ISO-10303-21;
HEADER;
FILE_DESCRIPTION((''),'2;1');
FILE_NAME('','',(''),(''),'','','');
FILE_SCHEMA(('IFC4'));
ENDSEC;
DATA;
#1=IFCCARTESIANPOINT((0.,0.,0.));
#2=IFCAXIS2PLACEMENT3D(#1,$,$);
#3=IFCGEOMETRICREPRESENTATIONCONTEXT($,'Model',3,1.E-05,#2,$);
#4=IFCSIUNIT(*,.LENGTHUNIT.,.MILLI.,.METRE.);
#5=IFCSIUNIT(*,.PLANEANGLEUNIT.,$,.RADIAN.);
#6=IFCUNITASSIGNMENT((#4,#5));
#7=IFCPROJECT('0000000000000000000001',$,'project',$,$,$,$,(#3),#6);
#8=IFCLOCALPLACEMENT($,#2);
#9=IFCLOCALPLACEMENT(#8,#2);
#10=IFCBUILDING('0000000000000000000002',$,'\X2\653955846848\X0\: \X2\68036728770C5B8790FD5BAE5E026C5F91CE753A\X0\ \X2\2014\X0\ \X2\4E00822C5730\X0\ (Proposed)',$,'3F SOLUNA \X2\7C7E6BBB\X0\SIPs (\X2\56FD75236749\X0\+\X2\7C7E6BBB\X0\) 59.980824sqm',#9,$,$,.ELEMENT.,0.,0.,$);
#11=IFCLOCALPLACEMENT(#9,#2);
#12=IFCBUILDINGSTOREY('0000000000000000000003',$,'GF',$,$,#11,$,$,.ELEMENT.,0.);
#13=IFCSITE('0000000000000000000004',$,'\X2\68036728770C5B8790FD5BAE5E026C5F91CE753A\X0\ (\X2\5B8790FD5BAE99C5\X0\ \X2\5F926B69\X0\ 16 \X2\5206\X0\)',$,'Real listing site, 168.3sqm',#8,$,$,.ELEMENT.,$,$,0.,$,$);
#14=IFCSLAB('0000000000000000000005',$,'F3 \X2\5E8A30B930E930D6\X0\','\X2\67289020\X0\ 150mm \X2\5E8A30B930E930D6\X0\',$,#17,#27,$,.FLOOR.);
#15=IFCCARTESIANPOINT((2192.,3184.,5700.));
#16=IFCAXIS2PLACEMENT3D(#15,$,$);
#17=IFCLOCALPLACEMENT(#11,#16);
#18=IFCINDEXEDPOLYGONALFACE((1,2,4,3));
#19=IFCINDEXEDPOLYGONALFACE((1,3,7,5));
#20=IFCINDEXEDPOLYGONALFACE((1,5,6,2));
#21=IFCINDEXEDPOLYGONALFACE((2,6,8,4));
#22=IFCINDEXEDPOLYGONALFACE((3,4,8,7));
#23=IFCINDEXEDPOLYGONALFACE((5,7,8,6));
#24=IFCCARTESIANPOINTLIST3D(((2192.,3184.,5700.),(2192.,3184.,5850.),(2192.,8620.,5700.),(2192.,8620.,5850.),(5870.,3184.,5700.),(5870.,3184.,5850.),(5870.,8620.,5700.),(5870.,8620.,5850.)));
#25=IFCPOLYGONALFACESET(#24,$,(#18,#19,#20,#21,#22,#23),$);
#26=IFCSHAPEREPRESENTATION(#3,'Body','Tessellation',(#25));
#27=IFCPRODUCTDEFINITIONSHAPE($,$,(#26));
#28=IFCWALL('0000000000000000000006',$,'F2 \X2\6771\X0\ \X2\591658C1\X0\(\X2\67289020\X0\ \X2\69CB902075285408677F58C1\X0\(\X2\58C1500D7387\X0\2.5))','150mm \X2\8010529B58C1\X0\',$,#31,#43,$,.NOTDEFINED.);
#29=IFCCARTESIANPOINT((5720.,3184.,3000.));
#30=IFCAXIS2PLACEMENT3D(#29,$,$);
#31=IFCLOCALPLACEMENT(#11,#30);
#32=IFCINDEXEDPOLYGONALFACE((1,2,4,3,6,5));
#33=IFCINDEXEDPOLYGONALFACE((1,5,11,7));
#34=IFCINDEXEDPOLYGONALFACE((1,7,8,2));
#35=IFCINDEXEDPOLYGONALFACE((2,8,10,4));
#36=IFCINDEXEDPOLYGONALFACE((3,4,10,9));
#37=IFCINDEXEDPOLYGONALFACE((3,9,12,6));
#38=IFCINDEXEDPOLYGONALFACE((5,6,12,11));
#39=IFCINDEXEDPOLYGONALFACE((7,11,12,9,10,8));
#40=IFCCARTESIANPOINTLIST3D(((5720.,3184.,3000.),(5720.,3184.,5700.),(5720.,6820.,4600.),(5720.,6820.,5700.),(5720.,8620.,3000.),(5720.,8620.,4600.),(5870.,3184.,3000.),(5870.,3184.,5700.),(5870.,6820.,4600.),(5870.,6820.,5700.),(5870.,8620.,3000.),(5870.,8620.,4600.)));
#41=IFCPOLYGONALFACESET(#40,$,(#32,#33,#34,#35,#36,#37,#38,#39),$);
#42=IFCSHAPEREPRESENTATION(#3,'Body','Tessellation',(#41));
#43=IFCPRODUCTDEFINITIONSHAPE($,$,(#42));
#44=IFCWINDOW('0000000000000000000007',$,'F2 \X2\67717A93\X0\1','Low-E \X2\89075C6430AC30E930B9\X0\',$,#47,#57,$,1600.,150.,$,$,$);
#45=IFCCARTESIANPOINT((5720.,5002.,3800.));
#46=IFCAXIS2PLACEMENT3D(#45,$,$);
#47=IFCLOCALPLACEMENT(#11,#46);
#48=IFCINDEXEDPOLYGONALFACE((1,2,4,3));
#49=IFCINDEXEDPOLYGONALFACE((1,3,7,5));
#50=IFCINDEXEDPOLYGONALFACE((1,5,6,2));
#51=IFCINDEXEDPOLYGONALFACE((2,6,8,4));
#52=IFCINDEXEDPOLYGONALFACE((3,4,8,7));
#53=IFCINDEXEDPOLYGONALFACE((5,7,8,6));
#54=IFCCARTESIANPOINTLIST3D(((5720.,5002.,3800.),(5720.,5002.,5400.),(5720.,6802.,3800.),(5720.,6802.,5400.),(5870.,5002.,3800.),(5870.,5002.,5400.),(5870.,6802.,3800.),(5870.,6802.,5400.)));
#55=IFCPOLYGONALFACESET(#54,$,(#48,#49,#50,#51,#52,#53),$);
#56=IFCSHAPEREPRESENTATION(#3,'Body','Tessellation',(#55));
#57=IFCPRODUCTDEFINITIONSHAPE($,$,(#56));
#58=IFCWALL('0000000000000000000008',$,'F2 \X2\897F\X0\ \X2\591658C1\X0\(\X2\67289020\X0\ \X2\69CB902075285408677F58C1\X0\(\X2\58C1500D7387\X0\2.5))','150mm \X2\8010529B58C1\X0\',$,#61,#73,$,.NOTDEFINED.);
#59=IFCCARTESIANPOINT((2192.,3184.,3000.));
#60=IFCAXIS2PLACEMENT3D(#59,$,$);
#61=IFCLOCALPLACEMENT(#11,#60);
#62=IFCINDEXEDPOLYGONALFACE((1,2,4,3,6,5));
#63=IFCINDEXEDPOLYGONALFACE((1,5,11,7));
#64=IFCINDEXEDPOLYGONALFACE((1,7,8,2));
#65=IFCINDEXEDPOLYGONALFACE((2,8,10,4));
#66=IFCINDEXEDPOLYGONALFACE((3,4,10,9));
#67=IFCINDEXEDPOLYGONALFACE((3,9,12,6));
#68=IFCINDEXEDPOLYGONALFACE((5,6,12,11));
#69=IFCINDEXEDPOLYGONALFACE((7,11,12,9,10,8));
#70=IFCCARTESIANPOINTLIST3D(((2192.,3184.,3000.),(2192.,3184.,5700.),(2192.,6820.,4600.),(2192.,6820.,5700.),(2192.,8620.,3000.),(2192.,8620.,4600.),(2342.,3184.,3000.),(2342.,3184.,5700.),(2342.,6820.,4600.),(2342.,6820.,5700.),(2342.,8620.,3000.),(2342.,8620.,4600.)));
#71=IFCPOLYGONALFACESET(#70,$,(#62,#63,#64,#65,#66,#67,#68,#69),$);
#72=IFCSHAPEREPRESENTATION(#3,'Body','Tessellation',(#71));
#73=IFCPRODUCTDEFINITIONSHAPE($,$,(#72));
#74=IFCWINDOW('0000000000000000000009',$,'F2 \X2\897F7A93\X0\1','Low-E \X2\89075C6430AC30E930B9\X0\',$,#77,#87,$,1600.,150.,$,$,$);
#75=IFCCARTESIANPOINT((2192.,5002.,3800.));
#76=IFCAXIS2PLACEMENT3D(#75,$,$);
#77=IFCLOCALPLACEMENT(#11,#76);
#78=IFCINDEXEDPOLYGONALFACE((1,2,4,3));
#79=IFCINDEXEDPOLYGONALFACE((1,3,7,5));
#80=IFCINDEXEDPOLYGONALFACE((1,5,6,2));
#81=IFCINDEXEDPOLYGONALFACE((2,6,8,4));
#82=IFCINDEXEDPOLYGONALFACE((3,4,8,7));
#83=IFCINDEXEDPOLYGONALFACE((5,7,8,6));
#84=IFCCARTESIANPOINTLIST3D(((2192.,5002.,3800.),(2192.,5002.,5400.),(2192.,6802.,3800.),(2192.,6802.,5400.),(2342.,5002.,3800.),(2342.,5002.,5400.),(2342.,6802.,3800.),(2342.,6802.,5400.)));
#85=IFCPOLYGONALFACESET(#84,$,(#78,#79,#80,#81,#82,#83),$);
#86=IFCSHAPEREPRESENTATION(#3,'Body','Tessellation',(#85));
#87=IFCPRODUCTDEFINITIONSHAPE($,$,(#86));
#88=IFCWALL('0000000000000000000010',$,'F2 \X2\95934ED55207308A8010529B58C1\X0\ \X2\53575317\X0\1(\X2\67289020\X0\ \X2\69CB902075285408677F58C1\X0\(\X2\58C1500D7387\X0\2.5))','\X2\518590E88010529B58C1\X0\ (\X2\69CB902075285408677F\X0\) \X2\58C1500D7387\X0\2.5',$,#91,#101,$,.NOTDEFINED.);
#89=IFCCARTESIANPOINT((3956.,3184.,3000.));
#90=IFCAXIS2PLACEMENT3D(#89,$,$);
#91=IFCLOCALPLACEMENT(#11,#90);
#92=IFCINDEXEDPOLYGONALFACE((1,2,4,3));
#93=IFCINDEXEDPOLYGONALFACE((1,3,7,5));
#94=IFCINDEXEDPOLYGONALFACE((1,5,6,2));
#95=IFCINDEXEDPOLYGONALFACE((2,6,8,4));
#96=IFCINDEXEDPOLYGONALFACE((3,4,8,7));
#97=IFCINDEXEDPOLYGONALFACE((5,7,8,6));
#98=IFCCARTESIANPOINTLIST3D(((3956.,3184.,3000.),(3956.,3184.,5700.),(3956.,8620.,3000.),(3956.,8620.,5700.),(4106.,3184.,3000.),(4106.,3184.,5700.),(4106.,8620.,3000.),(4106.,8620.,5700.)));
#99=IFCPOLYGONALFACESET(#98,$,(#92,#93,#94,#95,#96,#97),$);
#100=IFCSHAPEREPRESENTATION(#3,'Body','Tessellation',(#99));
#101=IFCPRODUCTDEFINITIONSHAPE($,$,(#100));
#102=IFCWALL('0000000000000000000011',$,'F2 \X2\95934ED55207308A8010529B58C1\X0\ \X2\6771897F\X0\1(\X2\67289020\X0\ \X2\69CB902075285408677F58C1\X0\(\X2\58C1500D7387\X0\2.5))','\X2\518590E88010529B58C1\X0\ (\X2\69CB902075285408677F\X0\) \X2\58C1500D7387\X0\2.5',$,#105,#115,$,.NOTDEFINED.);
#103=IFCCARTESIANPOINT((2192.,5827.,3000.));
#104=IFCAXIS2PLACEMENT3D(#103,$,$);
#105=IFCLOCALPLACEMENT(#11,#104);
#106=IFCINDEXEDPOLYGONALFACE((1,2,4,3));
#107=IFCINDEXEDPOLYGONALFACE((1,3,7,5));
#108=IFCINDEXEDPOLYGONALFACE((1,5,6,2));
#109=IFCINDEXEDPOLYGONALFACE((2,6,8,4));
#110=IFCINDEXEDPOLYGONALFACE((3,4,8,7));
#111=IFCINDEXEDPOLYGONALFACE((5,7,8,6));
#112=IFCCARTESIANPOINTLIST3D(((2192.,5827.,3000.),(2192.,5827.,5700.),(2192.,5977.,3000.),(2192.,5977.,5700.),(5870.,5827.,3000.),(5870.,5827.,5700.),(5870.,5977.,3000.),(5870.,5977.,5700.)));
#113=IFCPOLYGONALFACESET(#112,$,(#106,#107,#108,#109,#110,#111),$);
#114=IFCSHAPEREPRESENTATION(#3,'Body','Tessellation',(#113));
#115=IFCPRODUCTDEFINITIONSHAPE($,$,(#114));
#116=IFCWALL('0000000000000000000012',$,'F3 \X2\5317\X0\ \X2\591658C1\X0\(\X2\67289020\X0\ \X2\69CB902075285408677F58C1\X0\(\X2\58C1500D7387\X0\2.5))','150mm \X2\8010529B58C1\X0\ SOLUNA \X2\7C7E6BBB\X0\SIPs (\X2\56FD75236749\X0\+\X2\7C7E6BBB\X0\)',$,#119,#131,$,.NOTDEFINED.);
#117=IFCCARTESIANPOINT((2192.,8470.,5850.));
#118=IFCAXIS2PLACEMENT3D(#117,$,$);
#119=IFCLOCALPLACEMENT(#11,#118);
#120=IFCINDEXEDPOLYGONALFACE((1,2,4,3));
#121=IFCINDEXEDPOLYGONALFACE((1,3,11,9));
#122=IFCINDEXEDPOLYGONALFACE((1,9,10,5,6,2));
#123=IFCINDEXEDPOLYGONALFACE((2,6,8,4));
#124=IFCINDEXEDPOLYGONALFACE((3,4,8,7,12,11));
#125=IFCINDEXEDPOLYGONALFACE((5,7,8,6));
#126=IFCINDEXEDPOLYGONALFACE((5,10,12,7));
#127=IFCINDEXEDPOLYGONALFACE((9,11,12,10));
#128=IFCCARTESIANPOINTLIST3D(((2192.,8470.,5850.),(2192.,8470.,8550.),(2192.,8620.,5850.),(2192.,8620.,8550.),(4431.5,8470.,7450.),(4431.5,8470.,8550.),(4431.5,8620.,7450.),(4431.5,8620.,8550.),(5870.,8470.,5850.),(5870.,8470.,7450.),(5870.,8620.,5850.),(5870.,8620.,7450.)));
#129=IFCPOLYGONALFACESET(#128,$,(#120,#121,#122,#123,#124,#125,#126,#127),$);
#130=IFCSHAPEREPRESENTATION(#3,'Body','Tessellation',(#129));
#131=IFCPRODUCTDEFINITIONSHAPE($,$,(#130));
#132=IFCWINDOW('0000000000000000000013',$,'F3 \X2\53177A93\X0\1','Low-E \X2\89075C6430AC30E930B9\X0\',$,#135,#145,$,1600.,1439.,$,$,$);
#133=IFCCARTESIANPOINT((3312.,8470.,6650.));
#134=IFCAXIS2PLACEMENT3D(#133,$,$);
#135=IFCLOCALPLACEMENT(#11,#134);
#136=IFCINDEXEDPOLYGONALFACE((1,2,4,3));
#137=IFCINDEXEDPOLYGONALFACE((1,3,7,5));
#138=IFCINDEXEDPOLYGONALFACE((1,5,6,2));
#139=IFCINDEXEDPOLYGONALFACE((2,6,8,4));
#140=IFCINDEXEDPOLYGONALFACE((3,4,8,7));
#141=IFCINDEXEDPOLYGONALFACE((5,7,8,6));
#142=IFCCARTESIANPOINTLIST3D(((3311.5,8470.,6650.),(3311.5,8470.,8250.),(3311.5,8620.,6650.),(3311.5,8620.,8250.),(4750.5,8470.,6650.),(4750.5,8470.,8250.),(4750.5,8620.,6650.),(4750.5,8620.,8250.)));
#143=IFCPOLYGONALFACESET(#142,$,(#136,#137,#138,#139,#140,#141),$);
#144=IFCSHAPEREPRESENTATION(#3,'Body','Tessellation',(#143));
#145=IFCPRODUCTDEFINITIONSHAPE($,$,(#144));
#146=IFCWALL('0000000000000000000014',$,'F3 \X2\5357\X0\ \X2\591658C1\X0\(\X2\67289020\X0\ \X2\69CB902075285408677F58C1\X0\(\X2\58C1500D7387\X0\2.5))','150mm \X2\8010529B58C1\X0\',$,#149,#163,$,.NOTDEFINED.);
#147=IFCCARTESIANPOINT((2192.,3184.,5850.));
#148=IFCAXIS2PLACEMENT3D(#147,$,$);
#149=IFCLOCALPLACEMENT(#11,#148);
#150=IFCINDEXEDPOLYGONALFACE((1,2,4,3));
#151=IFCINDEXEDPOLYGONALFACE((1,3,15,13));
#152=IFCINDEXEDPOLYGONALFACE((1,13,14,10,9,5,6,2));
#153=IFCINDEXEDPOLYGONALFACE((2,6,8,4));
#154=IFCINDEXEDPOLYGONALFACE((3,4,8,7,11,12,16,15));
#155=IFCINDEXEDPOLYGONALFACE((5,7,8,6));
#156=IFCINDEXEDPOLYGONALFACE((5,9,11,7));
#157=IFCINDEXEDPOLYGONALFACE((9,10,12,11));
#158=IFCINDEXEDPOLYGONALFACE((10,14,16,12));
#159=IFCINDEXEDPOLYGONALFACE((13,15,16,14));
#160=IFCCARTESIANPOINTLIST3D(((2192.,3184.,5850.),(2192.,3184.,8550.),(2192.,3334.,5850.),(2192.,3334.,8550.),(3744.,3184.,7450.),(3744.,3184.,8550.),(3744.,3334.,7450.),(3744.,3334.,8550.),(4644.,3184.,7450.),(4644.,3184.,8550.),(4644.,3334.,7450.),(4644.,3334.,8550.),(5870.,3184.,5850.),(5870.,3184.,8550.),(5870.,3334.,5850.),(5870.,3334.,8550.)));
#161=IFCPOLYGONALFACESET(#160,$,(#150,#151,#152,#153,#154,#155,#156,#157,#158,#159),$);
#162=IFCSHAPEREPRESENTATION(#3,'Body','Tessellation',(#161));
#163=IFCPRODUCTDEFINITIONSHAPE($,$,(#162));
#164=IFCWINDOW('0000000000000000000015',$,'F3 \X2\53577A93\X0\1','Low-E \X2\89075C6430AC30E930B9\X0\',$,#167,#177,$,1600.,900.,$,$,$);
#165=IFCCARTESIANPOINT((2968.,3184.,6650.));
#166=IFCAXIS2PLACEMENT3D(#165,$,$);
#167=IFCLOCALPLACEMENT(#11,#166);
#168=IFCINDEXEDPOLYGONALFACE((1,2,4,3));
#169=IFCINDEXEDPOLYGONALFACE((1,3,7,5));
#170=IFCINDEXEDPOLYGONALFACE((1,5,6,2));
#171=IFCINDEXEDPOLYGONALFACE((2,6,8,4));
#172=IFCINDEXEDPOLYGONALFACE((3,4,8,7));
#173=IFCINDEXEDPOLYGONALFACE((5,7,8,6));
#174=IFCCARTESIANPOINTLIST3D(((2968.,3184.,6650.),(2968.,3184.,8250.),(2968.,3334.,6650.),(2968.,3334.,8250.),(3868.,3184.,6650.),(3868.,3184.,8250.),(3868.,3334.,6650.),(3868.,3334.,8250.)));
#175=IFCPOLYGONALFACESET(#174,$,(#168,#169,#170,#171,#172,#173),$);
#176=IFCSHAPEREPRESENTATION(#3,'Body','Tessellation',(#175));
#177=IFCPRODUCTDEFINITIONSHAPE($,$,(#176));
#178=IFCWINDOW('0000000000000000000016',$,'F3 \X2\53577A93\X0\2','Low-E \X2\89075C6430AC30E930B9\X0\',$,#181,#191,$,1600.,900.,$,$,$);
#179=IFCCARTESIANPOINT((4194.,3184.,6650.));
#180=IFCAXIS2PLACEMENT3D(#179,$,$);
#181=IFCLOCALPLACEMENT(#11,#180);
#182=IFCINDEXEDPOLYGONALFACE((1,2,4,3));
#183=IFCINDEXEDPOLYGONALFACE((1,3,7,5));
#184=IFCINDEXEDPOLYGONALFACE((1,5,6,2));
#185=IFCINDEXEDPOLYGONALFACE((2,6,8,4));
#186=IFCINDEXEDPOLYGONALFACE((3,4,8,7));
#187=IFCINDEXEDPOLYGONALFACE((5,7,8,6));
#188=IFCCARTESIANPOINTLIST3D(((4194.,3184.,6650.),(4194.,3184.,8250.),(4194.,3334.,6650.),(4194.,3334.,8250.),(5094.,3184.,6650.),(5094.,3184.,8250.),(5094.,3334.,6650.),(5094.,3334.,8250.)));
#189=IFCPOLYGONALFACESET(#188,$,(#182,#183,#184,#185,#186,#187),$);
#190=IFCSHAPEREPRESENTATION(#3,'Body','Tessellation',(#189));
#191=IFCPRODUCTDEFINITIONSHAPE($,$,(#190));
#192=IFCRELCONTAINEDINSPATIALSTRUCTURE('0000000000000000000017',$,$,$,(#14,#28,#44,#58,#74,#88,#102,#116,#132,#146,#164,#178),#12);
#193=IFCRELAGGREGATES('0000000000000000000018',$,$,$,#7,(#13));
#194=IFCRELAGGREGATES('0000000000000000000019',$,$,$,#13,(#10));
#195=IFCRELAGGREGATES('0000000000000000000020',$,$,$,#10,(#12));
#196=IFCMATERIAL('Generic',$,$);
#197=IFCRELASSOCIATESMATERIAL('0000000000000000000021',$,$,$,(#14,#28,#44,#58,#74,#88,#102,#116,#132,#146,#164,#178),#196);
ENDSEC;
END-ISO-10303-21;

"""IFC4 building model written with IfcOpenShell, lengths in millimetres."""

from ifc_helpers import new_model, si_unit, frame, frame_2d, origin, place, context, project, spatial, rectangle, extrude, material, element, fill, save


model = new_model("IFC4")

# Units and contexts
model_context = context("Model", 3, precision=1e-05, world=origin())
ifc_project = project(units=[si_unit("LENGTHUNIT", "METRE", prefix="MILLI"), si_unit("PLANEANGLEUNIT", "RADIAN")], contexts=[model_context])

# Site, building, storey
site_placement = place(None, origin())
site = spatial("IfcSite", under=ifc_project, at=site_placement, Name="栃木県宇都宮市江野町 (宇都宮駅 徒歩 16 分)", ObjectType="Real listing site, 168.3sqm", CompositionType="ELEMENT", RefElevation=0.0)
building_placement = place(site_placement, origin())
building = spatial("IfcBuilding", under=site, at=building_placement, Name="改善案: 栃木県宇都宮市江野町 — 一般地 (Proposed)", ObjectType="3F SOLUNA 籾殻SIPs (国産杉+籾殻) 59.980824sqm", CompositionType="ELEMENT", ElevationOfRefHeight=0.0, ElevationOfTerrain=0.0)
storey_placement = place(building_placement, origin())
storey = spatial("IfcBuildingStorey", under=building, at=storey_placement, Name="GF", CompositionType="ELEMENT", Elevation=0.0)

# Slab
ifc_material_1 = material(Name="Generic")
slab_placement = place(storey_placement, frame((2192.0, 3184.0, 5700.0)))
element("IfcSlab", 1, at=slab_placement, inside=storey, material=ifc_material_1, Name="F3 床スラブ", Description="木造 150mm 床スラブ", PredefinedType="FLOOR", context=model_context, shape_type="SweptSolid", body=[
    extrude(rectangle(XDim=3678.0, YDim=5436.0, at=frame_2d((1839.0, 2718.0))), frame((2192.0, 3184.0, 5700.0)), (0.0, 0.0, 1.0), 150.0),
])

# Walls, openings, windows
wall_1_placement = place(storey_placement, frame((5720.0, 3184.0, 3000.0)))
wall_1 = element("IfcWall", 2, at=wall_1_placement, inside=storey, material=ifc_material_1, Name="F2 東 外壁(木造 構造用合板壁(壁倍率2.5))", Description="150mm 耐力壁", PredefinedType="NOTDEFINED", context=model_context, shape_type="SweptSolid", body=[
    extrude(rectangle(XDim=150.0, YDim=5436.0, at=frame_2d((75.0, 2718.0))), frame((5720.0, 3184.0, 3000.0)), (0.0, 0.0, 1.0), 2700.0),
])
opening_1_placement = place(storey_placement, frame((5720.0, 5002.0, 3800.0)))
opening_1 = element("IfcOpeningElement", 3, at=opening_1_placement, cuts=wall_1, PredefinedType="NOTDEFINED", context=model_context, shape_type="SweptSolid", body=[
    extrude(rectangle(XDim=150.0, YDim=1800.0, at=frame_2d((75.0, 900.0))), frame((5720.0, 5002.0, 3800.0)), (0.0, 0.0, 1.0), 1600.0),
])
window_1_placement = place(storey_placement, frame((5720.0, 5002.0, 3800.0)))
window_1 = element("IfcWindow", 4, at=window_1_placement, inside=storey, material=ifc_material_1, Name="F2 東窓1", Description="Low-E 複層ガラス", OverallHeight=1600.0, OverallWidth=150.0, context=model_context, shape_type="SweptSolid", body=[
    extrude(rectangle(XDim=150.0, YDim=1800.0, at=frame_2d((75.0, 900.0))), frame((5720.0, 5002.0, 3800.0)), (0.0, 0.0, 1.0), 1600.0),
])
fill(opening_1, window_1)
wall_2_placement = place(storey_placement, frame((2192.0, 3184.0, 3000.0)))
wall_2 = element("IfcWall", 5, at=wall_2_placement, inside=storey, material=ifc_material_1, Name="F2 西 外壁(木造 構造用合板壁(壁倍率2.5))", Description="150mm 耐力壁", PredefinedType="NOTDEFINED", context=model_context, shape_type="SweptSolid", body=[
    extrude(rectangle(XDim=150.0, YDim=5436.0, at=frame_2d((75.0, 2718.0))), frame((2192.0, 3184.0, 3000.0)), (0.0, 0.0, 1.0), 2700.0),
])
opening_2_placement = place(storey_placement, frame((2192.0, 5002.0, 3800.0)))
opening_2 = element("IfcOpeningElement", 6, at=opening_2_placement, cuts=wall_2, PredefinedType="NOTDEFINED", context=model_context, shape_type="SweptSolid", body=[
    extrude(rectangle(XDim=150.0, YDim=1800.0, at=frame_2d((75.0, 900.0))), frame((2192.0, 5002.0, 3800.0)), (0.0, 0.0, 1.0), 1600.0),
])
window_2_placement = place(storey_placement, frame((2192.0, 5002.0, 3800.0)))
window_2 = element("IfcWindow", 7, at=window_2_placement, inside=storey, material=ifc_material_1, Name="F2 西窓1", Description="Low-E 複層ガラス", OverallHeight=1600.0, OverallWidth=150.0, context=model_context, shape_type="SweptSolid", body=[
    extrude(rectangle(XDim=150.0, YDim=1800.0, at=frame_2d((75.0, 900.0))), frame((2192.0, 5002.0, 3800.0)), (0.0, 0.0, 1.0), 1600.0),
])
fill(opening_2, window_2)

# Walls
wall_3_placement = place(storey_placement, frame((3956.0, 3184.0, 3000.0)))
element("IfcWall", 8, at=wall_3_placement, inside=storey, material=ifc_material_1, Name="F2 間仕切り耐力壁 南北1(木造 構造用合板壁(壁倍率2.5))", Description="内部耐力壁 (構造用合板) 壁倍率2.5", PredefinedType="NOTDEFINED", context=model_context, shape_type="SweptSolid", body=[
    extrude(rectangle(XDim=150.0, YDim=5436.0, at=frame_2d((75.0, 2718.0))), frame((3956.0, 3184.0, 3000.0)), (0.0, 0.0, 1.0), 2700.0),
])
wall_4_placement = place(storey_placement, frame((2192.0, 5827.0, 3000.0)))
element("IfcWall", 9, at=wall_4_placement, inside=storey, material=ifc_material_1, Name="F2 間仕切り耐力壁 東西1(木造 構造用合板壁(壁倍率2.5))", Description="内部耐力壁 (構造用合板) 壁倍率2.5", PredefinedType="NOTDEFINED", context=model_context, shape_type="SweptSolid", body=[
    extrude(rectangle(XDim=3678.0, YDim=150.0, at=frame_2d((1839.0, 75.0))), frame((2192.0, 5827.0, 3000.0)), (0.0, 0.0, 1.0), 2700.0),
])

# Wall, opening, window
wall_5_placement = place(storey_placement, frame((2192.0, 8470.0, 5850.0)))
wall_5 = element("IfcWall", 10, at=wall_5_placement, inside=storey, material=ifc_material_1, Name="F3 北 外壁(木造 構造用合板壁(壁倍率2.5))", Description="150mm 耐力壁 SOLUNA 籾殻SIPs (国産杉+籾殻)", PredefinedType="NOTDEFINED", context=model_context, shape_type="SweptSolid", body=[
    extrude(rectangle(XDim=3678.0, YDim=150.0, at=frame_2d((1839.0, 75.0))), frame((2192.0, 8470.0, 5850.0)), (0.0, 0.0, 1.0), 2700.0),
])
opening_3_placement = place(storey_placement, frame((3312.0, 8470.0, 6650.0)))
opening_3 = element("IfcOpeningElement", 11, at=opening_3_placement, cuts=wall_5, PredefinedType="NOTDEFINED", context=model_context, shape_type="SweptSolid", body=[
    extrude(rectangle(XDim=1439.0, YDim=150.0, at=frame_2d((719.0, 75.0))), frame((3312.0, 8470.0, 6650.0)), (0.0, 0.0, 1.0), 1600.0),
])
window_3_placement = place(storey_placement, frame((3312.0, 8470.0, 6650.0)))
window_3 = element("IfcWindow", 12, at=window_3_placement, inside=storey, material=ifc_material_1, Name="F3 北窓1", Description="Low-E 複層ガラス", OverallHeight=1600.0, OverallWidth=1439.0, context=model_context, shape_type="SweptSolid", body=[
    extrude(rectangle(XDim=1439.0, YDim=150.0, at=frame_2d((719.0, 75.0))), frame((3312.0, 8470.0, 6650.0)), (0.0, 0.0, 1.0), 1600.0),
])
fill(opening_3, window_3)

# Wall, openings, windows
wall_6_placement = place(storey_placement, frame((2192.0, 3184.0, 5850.0)))
wall_6 = element("IfcWall", 13, at=wall_6_placement, inside=storey, material=ifc_material_1, Name="F3 南 外壁(木造 構造用合板壁(壁倍率2.5))", Description="150mm 耐力壁", PredefinedType="NOTDEFINED", context=model_context, shape_type="SweptSolid", body=[
    extrude(rectangle(XDim=3678.0, YDim=150.0, at=frame_2d((1839.0, 75.0))), frame((2192.0, 3184.0, 5850.0)), (0.0, 0.0, 1.0), 2700.0),
])
opening_4_placement = place(storey_placement, frame((2968.0, 3184.0, 6650.0)))
opening_4 = element("IfcOpeningElement", 14, at=opening_4_placement, cuts=wall_6, PredefinedType="NOTDEFINED", context=model_context, shape_type="SweptSolid", body=[
    extrude(rectangle(XDim=900.0, YDim=150.0, at=frame_2d((450.0, 75.0))), frame((2968.0, 3184.0, 6650.0)), (0.0, 0.0, 1.0), 1600.0),
])
opening_5_placement = place(storey_placement, frame((4194.0, 3184.0, 6650.0)))
opening_5 = element("IfcOpeningElement", 15, at=opening_5_placement, cuts=wall_6, PredefinedType="NOTDEFINED", context=model_context, shape_type="SweptSolid", body=[
    extrude(rectangle(XDim=900.0, YDim=150.0, at=frame_2d((450.0, 75.0))), frame((4194.0, 3184.0, 6650.0)), (0.0, 0.0, 1.0), 1600.0),
])
window_4_placement = place(storey_placement, frame((2968.0, 3184.0, 6650.0)))
window_4 = element("IfcWindow", 16, at=window_4_placement, inside=storey, material=ifc_material_1, Name="F3 南窓1", Description="Low-E 複層ガラス", OverallHeight=1600.0, OverallWidth=900.0, context=model_context, shape_type="SweptSolid", body=[
    extrude(rectangle(XDim=900.0, YDim=150.0, at=frame_2d((450.0, 75.0))), frame((2968.0, 3184.0, 6650.0)), (0.0, 0.0, 1.0), 1600.0),
])
fill(opening_4, window_4)
window_5_placement = place(storey_placement, frame((4194.0, 3184.0, 6650.0)))
window_5 = element("IfcWindow", 17, at=window_5_placement, inside=storey, material=ifc_material_1, Name="F3 南窓2", Description="Low-E 複層ガラス", OverallHeight=1600.0, OverallWidth=900.0, context=model_context, shape_type="SweptSolid", body=[
    extrude(rectangle(XDim=900.0, YDim=150.0, at=frame_2d((450.0, 75.0))), frame((4194.0, 3184.0, 6650.0)), (0.0, 0.0, 1.0), 1600.0),
])
fill(opening_5, window_5)

save(model, "model.ifc")
